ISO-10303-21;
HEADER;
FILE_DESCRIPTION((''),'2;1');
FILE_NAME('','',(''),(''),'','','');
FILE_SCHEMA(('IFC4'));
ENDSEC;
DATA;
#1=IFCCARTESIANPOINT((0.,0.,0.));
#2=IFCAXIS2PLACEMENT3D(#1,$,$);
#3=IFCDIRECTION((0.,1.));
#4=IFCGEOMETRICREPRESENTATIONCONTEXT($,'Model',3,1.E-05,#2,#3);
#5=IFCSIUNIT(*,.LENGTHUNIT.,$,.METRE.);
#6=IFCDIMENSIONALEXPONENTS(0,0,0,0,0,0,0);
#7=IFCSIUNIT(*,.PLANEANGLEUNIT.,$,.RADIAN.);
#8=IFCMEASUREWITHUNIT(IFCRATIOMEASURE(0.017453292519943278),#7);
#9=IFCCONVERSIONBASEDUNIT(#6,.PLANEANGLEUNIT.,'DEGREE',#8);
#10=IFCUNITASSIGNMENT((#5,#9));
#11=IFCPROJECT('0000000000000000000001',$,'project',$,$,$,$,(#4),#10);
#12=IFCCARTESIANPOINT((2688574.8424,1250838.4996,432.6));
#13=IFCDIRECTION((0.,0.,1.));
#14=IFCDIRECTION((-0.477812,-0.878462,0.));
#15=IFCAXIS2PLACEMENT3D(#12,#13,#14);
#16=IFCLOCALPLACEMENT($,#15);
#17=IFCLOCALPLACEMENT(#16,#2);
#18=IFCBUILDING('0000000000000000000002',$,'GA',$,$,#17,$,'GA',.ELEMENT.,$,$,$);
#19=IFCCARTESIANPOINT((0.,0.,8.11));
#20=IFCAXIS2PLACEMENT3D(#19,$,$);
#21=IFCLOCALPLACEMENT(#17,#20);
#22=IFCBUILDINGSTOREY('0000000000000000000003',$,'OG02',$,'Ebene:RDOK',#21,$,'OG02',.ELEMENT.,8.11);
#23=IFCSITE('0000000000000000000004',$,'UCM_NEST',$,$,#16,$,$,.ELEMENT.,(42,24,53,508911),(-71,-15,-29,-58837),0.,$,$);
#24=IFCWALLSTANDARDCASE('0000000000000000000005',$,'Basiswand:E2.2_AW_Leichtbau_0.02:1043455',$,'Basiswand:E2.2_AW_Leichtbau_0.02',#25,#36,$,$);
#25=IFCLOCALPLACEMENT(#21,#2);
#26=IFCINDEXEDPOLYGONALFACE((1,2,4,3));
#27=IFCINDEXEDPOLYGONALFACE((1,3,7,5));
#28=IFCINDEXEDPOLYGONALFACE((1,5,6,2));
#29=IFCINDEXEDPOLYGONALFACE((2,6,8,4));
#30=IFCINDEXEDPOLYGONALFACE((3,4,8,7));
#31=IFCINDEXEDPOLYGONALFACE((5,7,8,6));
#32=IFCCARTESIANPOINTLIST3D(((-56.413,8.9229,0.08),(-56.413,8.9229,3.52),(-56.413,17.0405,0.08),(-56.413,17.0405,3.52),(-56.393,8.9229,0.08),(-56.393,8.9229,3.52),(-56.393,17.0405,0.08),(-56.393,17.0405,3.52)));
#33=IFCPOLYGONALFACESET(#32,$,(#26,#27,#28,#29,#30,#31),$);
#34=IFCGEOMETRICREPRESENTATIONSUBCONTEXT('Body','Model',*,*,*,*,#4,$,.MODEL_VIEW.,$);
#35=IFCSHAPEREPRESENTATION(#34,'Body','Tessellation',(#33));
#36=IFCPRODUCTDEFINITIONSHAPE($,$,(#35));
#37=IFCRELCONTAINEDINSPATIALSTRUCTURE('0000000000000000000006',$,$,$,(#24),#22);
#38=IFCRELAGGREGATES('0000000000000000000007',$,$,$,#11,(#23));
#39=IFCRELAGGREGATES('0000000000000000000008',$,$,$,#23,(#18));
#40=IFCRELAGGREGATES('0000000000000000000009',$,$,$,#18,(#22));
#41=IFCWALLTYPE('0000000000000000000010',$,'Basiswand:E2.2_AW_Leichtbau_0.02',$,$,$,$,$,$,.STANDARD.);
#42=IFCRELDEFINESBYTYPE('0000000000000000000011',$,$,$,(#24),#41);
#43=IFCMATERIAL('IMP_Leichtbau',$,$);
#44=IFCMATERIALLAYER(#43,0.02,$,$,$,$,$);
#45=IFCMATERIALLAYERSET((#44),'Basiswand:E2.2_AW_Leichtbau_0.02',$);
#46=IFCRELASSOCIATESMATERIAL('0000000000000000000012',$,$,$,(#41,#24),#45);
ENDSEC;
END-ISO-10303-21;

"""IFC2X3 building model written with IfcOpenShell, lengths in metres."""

from ifc_helpers import new_model, entity, si_unit, converted_unit, direction, frame, frame_2d, origin, place, context, subcontext, project, spatial, polyline, rectangle, extrude, clip, bounded_halfspace, material, layer, layer_set, layer_usage, type_object, element, save


model = new_model("IFC2X3")

# Units and contexts
model_context = context("Model", 3, precision=1e-05, world=origin(), true_north=direction((0.0, 1.0)))
body_context = subcontext(model_context, "Body", "Model", "MODEL_VIEW")
ifc_project = project(units=[si_unit("LENGTHUNIT", "METRE"), converted_unit("PLANEANGLEUNIT", "DEGREE", entity("IfcRatioMeasure", 0.017453292519943278), si_unit("PLANEANGLEUNIT", "RADIAN"), dimensions=[0, 0, 0, 0, 0, 0, 0])], contexts=[model_context])

# Site, building, storey
site_placement = place(None, frame((2688574.8424, 1250838.4996, 432.6), z_axis=(0.0, 0.0, 1.0), x_axis=(-0.477812, -0.878462, 0.0)))
site = spatial("IfcSite", under=ifc_project, at=site_placement, Name="UCM_NEST", CompositionType="ELEMENT", RefLatitude=(42, 24, 53, 508911), RefLongitude=(-71, -15, -29, -58837), RefElevation=0.0)
building_placement = place(site_placement, origin())
building = spatial("IfcBuilding", under=site, at=building_placement, Name="GA", LongName="GA", CompositionType="ELEMENT")
storey_placement = place(building_placement, frame((0.0, 0.0, 8.11)))
storey = spatial("IfcBuildingStorey", under=building, at=storey_placement, Name="OG02", ObjectType="Ebene:RDOK", LongName="OG02", CompositionType="ELEMENT", Elevation=8.11)

# Wall
ifc_material_1 = material(Name="IMP_Leichtbau")
ifc_layer_1 = layer(ifc_material_1, 0.02)
ifc_layer_set_1 = layer_set([ifc_layer_1], Name="Basiswand:E2.2_AW_Leichtbau_0.02")
ifc_layer_usage_1 = layer_usage(ifc_layer_set_1, "AXIS2", "NEGATIVE", 0.01)
wall_type_1 = type_object("IfcWallType", Name="Basiswand:E2.2_AW_Leichtbau_0.02", PredefinedType="STANDARD", material=ifc_layer_set_1)
wall_1_placement = place(storey_placement, frame((-56.403, 8.9229, 0.08), z_axis=(0.0, 0.0, 1.0), x_axis=(0.0, 1.0, 0.0)))
element("IfcWallStandardCase", 1, at=wall_1_placement, inside=storey, type_object=wall_type_1, material=ifc_layer_usage_1, Name="Basiswand:E2.2_AW_Leichtbau_0.02:1043455", ObjectType="Basiswand:E2.2_AW_Leichtbau_0.02", context=body_context, shape_type="Clipping", body=[
    clip(clip(extrude(rectangle(XDim=8.1177, YDim=0.02, at=frame_2d((4.0588, 0.0), x_axis=(-1.0, 0.0))), origin(), (0.0, 0.0, 1.0), 3.44), bounded_halfspace(frame((0.0, -0.01, 3.44), z_axis=(0.0, 0.0, -1.0), x_axis=(0.0, 1.0, 0.0)), True, frame((0.0, -0.01, 3.44), z_axis=(0.0, 0.0, -1.0), x_axis=(0.0, 1.0, 0.0)), polyline([(0.0, 0.0), (0.02, 0.0), (0.02, 8.1177), (0.0, 8.1177), (0.0, 0.0)]))), bounded_halfspace(frame((8.1177, -0.01, 0.0), z_axis=(0.0, 0.0, 1.0), x_axis=(0.0, 1.0, 0.0)), True, frame((8.1177, -0.01, 0.0), z_axis=(0.0, 0.0, 1.0), x_axis=(0.0, 1.0, 0.0)), polyline([(0.0, 0.0), (0.02, 0.0), (0.02, 8.1177), (0.0, 8.1177), (0.0, 0.0)]))),
])

save(model, "model.ifc")
